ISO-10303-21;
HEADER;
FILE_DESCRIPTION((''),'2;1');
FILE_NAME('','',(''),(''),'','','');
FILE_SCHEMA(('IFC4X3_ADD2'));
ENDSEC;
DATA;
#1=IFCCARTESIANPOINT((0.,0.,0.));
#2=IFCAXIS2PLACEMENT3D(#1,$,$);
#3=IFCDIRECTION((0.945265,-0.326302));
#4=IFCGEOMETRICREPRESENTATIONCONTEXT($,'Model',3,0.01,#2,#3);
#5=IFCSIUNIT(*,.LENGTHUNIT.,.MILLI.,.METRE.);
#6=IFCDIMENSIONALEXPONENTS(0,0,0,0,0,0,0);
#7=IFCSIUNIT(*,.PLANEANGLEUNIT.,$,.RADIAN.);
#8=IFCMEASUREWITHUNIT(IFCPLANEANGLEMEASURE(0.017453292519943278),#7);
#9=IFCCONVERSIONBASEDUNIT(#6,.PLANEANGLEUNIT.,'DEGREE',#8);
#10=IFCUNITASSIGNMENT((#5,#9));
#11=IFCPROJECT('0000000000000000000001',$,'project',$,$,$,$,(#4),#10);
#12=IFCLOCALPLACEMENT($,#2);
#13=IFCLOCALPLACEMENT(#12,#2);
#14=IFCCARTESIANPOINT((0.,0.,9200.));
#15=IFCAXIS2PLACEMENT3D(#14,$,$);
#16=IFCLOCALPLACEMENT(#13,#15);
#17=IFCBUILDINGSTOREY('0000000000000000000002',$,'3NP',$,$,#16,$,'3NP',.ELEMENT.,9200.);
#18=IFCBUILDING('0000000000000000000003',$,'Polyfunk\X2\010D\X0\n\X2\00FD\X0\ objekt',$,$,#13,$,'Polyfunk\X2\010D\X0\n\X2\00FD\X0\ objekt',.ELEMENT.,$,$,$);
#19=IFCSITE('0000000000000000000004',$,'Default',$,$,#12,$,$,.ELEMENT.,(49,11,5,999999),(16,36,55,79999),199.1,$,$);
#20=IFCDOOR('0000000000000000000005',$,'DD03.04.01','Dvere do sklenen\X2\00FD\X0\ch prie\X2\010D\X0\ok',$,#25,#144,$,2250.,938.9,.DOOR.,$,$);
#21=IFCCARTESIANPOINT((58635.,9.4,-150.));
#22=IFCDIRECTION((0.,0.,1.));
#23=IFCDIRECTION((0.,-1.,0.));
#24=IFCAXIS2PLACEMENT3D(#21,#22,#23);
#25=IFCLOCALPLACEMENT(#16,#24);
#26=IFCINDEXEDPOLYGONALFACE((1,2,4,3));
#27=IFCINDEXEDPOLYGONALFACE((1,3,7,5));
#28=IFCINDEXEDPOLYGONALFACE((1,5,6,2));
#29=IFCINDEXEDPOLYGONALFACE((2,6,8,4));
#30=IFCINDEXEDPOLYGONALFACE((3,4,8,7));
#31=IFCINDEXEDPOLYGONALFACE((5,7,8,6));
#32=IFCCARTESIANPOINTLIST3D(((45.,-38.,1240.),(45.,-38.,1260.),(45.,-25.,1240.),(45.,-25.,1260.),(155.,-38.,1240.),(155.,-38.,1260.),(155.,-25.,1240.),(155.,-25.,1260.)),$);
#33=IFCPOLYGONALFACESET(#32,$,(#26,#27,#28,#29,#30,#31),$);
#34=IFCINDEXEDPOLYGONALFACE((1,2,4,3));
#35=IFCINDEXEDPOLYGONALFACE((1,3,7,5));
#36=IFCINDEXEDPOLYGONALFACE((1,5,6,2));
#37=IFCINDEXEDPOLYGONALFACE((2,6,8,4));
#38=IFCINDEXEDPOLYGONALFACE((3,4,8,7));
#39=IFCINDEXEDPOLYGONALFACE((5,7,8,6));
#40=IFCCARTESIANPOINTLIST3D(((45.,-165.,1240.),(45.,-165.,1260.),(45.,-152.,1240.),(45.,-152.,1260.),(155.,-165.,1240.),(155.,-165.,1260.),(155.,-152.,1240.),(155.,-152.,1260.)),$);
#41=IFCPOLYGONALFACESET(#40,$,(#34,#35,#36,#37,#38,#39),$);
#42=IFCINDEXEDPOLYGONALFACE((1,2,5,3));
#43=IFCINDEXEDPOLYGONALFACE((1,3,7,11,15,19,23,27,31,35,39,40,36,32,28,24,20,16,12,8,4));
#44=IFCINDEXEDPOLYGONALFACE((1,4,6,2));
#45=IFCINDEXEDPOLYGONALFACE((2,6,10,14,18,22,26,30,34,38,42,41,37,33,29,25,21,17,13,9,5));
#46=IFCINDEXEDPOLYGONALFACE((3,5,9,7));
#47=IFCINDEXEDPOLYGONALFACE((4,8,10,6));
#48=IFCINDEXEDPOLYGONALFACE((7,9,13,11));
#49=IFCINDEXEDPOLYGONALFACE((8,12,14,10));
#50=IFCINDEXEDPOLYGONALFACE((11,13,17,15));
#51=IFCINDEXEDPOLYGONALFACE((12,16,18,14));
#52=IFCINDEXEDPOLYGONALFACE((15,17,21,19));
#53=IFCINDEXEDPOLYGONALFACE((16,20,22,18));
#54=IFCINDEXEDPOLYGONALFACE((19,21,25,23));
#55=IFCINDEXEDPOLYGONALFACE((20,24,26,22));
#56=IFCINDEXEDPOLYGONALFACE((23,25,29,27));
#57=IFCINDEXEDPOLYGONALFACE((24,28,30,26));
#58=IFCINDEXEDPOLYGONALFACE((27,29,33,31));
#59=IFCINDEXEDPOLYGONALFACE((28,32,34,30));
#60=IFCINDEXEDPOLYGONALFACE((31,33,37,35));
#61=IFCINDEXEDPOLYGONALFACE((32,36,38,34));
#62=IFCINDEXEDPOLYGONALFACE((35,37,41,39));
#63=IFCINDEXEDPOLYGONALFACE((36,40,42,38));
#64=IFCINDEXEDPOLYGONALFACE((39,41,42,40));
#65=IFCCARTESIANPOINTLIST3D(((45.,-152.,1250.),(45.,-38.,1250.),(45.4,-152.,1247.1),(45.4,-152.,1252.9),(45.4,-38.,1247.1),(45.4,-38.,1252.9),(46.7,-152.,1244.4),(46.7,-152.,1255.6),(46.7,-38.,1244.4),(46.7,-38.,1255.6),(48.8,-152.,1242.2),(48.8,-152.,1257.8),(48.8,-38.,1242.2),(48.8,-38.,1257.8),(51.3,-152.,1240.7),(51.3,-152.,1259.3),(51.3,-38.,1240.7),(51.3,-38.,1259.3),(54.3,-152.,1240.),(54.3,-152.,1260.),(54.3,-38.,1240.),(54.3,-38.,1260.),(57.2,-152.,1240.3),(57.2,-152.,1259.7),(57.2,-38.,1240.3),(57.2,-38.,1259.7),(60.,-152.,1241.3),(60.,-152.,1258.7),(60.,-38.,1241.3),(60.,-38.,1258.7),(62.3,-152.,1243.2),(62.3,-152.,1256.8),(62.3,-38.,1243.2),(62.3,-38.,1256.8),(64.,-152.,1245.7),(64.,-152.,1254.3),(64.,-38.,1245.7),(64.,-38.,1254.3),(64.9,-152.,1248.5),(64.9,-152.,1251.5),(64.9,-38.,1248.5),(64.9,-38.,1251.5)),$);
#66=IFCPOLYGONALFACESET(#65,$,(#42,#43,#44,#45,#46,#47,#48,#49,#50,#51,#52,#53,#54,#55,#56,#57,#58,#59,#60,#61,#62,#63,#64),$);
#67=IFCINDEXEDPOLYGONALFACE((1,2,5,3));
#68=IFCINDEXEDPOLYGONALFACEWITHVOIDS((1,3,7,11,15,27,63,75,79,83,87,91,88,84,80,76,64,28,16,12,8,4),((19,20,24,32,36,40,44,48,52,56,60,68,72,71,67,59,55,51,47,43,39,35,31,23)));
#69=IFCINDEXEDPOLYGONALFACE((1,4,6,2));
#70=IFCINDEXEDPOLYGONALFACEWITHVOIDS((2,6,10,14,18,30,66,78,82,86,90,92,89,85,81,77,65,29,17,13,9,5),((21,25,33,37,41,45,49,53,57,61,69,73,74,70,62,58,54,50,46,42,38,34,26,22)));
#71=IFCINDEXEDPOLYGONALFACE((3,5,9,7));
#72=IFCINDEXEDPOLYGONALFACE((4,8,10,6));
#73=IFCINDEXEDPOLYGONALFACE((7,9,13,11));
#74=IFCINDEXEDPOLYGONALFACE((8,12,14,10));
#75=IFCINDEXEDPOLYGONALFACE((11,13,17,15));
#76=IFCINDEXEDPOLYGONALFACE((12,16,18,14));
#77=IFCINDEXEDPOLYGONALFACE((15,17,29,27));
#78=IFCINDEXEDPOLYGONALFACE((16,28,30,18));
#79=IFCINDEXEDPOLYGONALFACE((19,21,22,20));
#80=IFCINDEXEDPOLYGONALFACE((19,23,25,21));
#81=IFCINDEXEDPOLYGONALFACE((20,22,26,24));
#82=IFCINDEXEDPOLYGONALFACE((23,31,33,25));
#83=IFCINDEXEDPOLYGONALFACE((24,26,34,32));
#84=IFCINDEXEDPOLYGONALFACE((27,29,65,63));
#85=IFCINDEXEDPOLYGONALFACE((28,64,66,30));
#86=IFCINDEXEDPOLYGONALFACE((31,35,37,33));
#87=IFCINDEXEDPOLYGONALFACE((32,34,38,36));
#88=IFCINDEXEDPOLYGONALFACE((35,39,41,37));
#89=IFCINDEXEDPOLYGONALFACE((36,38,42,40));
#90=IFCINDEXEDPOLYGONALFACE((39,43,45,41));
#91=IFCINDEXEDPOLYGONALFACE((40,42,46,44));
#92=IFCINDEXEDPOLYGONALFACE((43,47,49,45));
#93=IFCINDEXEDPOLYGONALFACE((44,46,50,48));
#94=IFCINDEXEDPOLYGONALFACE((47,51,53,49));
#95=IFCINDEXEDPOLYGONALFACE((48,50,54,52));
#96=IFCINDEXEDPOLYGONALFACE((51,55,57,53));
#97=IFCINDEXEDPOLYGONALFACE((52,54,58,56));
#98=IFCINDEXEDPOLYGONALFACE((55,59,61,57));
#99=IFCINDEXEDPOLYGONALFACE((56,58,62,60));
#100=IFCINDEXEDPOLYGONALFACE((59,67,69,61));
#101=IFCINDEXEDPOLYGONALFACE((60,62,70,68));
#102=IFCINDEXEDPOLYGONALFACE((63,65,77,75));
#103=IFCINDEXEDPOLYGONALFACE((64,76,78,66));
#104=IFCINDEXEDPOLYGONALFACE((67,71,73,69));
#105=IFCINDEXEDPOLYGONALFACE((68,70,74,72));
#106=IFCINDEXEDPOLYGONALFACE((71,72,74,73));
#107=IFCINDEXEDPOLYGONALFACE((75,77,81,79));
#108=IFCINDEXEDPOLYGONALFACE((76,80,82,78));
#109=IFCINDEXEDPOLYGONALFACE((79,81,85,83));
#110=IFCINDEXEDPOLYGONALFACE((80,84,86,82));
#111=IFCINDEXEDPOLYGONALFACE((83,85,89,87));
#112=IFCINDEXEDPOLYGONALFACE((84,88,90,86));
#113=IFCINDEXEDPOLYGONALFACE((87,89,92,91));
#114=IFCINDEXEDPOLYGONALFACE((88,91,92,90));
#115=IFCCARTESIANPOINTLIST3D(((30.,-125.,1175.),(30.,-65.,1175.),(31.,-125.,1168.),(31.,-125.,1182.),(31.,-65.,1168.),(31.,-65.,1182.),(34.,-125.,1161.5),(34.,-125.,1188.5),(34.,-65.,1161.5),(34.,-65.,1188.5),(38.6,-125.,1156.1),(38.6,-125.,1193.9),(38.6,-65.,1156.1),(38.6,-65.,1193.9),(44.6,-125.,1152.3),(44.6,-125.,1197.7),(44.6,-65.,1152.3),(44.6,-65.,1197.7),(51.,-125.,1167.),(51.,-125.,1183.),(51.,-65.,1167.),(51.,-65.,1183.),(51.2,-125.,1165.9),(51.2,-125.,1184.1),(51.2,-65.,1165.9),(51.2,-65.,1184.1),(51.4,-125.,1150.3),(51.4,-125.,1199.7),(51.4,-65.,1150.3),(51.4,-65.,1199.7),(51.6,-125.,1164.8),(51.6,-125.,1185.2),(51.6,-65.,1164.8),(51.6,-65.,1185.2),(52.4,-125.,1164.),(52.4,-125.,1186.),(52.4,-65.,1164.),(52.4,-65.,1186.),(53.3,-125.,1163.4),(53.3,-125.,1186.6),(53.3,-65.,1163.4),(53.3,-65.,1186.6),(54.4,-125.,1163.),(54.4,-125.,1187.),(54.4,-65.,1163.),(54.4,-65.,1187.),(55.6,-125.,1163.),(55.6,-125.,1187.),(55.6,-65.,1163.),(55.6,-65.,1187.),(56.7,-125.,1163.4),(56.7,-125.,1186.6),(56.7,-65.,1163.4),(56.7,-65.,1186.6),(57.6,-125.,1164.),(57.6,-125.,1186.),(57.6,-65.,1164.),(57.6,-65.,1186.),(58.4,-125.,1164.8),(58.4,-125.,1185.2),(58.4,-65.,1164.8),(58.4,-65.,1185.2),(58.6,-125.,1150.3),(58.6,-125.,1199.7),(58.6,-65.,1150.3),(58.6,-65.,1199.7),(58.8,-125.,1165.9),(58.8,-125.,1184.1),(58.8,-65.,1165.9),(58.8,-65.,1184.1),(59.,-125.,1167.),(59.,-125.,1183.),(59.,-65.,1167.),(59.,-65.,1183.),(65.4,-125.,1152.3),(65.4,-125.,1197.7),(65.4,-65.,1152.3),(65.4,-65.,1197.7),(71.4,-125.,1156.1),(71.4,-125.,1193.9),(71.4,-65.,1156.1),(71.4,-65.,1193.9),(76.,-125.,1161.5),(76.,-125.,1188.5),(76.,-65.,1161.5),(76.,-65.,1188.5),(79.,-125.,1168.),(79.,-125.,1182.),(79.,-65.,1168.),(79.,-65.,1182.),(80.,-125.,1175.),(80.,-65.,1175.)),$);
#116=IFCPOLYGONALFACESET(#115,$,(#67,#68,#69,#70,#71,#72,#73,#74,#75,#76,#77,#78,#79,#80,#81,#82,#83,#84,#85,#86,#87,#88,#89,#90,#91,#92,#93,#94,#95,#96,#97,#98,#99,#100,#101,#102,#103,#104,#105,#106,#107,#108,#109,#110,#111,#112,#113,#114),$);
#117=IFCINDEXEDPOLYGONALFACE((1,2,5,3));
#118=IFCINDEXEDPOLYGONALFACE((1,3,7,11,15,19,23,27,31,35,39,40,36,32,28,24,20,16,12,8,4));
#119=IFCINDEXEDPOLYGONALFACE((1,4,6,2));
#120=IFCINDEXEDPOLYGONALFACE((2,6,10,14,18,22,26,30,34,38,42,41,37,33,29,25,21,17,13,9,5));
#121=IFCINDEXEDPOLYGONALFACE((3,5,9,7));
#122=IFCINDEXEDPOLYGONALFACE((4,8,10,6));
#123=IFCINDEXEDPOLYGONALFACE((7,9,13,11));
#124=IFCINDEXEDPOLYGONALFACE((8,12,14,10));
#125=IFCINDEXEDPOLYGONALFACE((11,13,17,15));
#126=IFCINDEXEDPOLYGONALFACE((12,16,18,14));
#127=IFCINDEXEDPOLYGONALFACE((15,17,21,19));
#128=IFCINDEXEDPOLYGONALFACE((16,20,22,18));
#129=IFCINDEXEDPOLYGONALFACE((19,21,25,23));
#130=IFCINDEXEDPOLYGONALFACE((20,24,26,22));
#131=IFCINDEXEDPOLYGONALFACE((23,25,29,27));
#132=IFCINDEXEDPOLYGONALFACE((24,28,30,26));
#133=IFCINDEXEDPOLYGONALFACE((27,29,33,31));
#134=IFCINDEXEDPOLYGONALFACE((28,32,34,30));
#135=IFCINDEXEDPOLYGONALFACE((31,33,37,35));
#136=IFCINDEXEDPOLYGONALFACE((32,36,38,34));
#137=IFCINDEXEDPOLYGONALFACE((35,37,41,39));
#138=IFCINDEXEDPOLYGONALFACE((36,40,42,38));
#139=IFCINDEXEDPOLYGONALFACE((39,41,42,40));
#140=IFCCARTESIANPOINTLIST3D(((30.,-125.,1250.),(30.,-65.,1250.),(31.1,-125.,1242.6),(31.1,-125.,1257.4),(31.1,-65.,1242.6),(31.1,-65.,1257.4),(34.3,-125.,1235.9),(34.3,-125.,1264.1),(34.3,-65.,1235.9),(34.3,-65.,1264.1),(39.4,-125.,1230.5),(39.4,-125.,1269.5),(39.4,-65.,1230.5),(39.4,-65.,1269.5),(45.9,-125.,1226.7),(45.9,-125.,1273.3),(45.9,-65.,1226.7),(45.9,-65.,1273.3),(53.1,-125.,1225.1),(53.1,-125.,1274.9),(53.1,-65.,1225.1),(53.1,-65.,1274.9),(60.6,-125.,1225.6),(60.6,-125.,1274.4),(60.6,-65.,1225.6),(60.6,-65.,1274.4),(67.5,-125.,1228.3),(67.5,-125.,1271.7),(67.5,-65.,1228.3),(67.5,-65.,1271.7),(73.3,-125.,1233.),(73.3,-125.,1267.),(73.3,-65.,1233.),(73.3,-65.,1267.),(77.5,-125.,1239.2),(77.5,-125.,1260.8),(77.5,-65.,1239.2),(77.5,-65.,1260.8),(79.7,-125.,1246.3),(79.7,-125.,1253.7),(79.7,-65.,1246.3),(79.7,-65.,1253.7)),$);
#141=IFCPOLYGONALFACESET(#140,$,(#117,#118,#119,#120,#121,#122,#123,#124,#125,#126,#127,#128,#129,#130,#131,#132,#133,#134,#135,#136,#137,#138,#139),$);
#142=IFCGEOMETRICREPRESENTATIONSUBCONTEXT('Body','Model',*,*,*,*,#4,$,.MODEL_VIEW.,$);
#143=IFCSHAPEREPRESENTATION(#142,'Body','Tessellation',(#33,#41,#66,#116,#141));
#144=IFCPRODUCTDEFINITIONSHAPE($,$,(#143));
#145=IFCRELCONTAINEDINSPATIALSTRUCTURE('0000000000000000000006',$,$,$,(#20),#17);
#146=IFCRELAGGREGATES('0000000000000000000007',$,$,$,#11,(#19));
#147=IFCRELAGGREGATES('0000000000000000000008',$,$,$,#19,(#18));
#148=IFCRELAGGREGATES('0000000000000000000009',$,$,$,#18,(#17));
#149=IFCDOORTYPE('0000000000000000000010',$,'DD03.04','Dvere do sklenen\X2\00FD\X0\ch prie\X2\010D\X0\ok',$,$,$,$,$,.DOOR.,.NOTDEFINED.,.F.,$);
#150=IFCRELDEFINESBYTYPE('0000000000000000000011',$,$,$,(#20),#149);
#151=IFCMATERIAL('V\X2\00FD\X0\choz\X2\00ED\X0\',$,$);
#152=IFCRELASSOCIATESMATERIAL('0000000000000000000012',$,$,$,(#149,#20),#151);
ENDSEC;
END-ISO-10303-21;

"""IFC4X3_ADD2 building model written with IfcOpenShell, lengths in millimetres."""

from ifc_helpers import new_model, entity, si_unit, converted_unit, direction, frame, frame_2d, origin, origin_2d_with_axis, place, context, subcontext, project, spatial, polyline, circle_curve, parameter, trimmed, segment, composite_curve, rectangle, circle, outline, extrude, source, transform, mapped, material, type_object, type_shapes, element, save


model = new_model("IFC4X3_ADD2")

# Units and contexts
model_context = context("Model", 3, precision=0.01, world=origin(), true_north=direction((0.945265, -0.326302)))
body_context = subcontext(model_context, "Body", "Model", "MODEL_VIEW")
ifc_project = project(units=[si_unit("LENGTHUNIT", "METRE", prefix="MILLI"), converted_unit("PLANEANGLEUNIT", "DEGREE", entity("IfcPlaneAngleMeasure", 0.017453292519943278), si_unit("PLANEANGLEUNIT", "RADIAN"), dimensions=[0, 0, 0, 0, 0, 0, 0])], contexts=[model_context])

# Site, building, storey
site_placement = place(None, origin())
site = spatial("IfcSite", under=ifc_project, at=site_placement, Name="Default", CompositionType="ELEMENT", RefLatitude=(49, 11, 5, 999999), RefLongitude=(16, 36, 55, 79999), RefElevation=199.1)
building_placement = place(site_placement, origin())
building = spatial("IfcBuilding", under=site, at=building_placement, Name="Polyfunkčný objekt", LongName="Polyfunkčný objekt", CompositionType="ELEMENT")
storey_placement = place(building_placement, frame((0.0, 0.0, 9200.0)))
storey = spatial("IfcBuildingStorey", under=building, at=storey_placement, Name="3NP", LongName="3NP", CompositionType="ELEMENT", Elevation=9200.0)

# Door
ifc_material_1 = material(Name="Výchozí")
door_type = type_object("IfcDoorType", Name="DD03.04", Description="Dvere do sklenených priečok", OperationType="NOTDEFINED", ParameterTakesPrecedence=False, PredefinedType="DOOR", material=ifc_material_1)
shared_shape_1 = source(origin(), body_context, "Body", "SweptSolid", [
    extrude(rectangle(XDim=110.0, YDim=13.0, at=frame_2d((0.0, 0.0), x_axis=(1.0, 0.0))), frame((100.0, -31.5, 1240.0)), (0.0, 0.0, 1.0), 20.0),
    extrude(rectangle(XDim=110.0, YDim=13.0, at=origin_2d_with_axis()), frame((100.0, -158.5, 1240.0), z_axis=(0.0, 0.0, 1.0), x_axis=(-1.0, 0.0, 0.0)), (0.0, 0.0, 1.0), 20.0),
    extrude(circle(Radius=10.0, at=origin_2d_with_axis()), frame((55.0, -152.0, 1250.0), z_axis=(0.0, 1.0, 0.0), x_axis=(-1.0, 0.0, 0.0)), (0.0, 0.0, 1.0), 114.0),
    extrude(outline(composite_curve([segment(trimmed(circle_curve(origin_2d_with_axis(), 25.0), [parameter(180.0)], [parameter(360.0)], True, "PARAMETER"), True, "CONTINUOUS"), segment(trimmed(circle_curve(origin_2d_with_axis(), 25.0), [parameter(0.0)], [parameter(180.0)], True, "PARAMETER"), True, "CONTINUOUS")], self_intersect=False), holes=[composite_curve([segment(trimmed(circle_curve(frame_2d((0.0, 8.0), x_axis=(1.0, 0.0)), 4.0), [parameter(0.0)], [parameter(180.0)], True, "PARAMETER"), False, "CONTINUOUS"), segment(polyline([(4.0, 8.0), (4.0, -8.0)]), True, "CONTINUOUS"), segment(trimmed(circle_curve(frame_2d((0.0, -8.0), x_axis=(1.0, 0.0)), 4.0), [parameter(180.0)], [parameter(0.0)], True, "PARAMETER"), False, "CONTINUOUS"), segment(polyline([(-4.0, -8.0), (-4.0, 8.0)]), True, "CONTINUOUS")], self_intersect=False)]), frame((55.0, -125.0, 1175.0), z_axis=(0.0, 1.0, 0.0), x_axis=(-1.0, 0.0, 0.0)), (0.0, 0.0, 1.0), 60.0),
    extrude(circle(Radius=25.0, at=frame_2d((0.0, 0.0), x_axis=(1.0, 0.0))), frame((55.0, -125.0, 1250.0), z_axis=(0.0, 1.0, 0.0), x_axis=(-1.0, 0.0, 0.0)), (0.0, 0.0, 1.0), 60.0),
])
type_shapes(door_type, [shared_shape_1])
door_placement = place(storey_placement, frame((58635.0, 9.4, -150.0), z_axis=(0.0, 0.0, 1.0), x_axis=(0.0, -1.0, 0.0)))
element("IfcDoor", 1, at=door_placement, inside=storey, type_object=door_type, material=ifc_material_1, Name="DD03.04.01", Description="Dvere do sklenených priečok", OverallHeight=2250.0, OverallWidth=938.9, PredefinedType="DOOR", context=body_context, shape_type="MappedRepresentation", body=[
    mapped(shared_shape_1, transform((0.0, 0.0, 0.0), scale=1.0)),
])

save(model, "model.ifc")
